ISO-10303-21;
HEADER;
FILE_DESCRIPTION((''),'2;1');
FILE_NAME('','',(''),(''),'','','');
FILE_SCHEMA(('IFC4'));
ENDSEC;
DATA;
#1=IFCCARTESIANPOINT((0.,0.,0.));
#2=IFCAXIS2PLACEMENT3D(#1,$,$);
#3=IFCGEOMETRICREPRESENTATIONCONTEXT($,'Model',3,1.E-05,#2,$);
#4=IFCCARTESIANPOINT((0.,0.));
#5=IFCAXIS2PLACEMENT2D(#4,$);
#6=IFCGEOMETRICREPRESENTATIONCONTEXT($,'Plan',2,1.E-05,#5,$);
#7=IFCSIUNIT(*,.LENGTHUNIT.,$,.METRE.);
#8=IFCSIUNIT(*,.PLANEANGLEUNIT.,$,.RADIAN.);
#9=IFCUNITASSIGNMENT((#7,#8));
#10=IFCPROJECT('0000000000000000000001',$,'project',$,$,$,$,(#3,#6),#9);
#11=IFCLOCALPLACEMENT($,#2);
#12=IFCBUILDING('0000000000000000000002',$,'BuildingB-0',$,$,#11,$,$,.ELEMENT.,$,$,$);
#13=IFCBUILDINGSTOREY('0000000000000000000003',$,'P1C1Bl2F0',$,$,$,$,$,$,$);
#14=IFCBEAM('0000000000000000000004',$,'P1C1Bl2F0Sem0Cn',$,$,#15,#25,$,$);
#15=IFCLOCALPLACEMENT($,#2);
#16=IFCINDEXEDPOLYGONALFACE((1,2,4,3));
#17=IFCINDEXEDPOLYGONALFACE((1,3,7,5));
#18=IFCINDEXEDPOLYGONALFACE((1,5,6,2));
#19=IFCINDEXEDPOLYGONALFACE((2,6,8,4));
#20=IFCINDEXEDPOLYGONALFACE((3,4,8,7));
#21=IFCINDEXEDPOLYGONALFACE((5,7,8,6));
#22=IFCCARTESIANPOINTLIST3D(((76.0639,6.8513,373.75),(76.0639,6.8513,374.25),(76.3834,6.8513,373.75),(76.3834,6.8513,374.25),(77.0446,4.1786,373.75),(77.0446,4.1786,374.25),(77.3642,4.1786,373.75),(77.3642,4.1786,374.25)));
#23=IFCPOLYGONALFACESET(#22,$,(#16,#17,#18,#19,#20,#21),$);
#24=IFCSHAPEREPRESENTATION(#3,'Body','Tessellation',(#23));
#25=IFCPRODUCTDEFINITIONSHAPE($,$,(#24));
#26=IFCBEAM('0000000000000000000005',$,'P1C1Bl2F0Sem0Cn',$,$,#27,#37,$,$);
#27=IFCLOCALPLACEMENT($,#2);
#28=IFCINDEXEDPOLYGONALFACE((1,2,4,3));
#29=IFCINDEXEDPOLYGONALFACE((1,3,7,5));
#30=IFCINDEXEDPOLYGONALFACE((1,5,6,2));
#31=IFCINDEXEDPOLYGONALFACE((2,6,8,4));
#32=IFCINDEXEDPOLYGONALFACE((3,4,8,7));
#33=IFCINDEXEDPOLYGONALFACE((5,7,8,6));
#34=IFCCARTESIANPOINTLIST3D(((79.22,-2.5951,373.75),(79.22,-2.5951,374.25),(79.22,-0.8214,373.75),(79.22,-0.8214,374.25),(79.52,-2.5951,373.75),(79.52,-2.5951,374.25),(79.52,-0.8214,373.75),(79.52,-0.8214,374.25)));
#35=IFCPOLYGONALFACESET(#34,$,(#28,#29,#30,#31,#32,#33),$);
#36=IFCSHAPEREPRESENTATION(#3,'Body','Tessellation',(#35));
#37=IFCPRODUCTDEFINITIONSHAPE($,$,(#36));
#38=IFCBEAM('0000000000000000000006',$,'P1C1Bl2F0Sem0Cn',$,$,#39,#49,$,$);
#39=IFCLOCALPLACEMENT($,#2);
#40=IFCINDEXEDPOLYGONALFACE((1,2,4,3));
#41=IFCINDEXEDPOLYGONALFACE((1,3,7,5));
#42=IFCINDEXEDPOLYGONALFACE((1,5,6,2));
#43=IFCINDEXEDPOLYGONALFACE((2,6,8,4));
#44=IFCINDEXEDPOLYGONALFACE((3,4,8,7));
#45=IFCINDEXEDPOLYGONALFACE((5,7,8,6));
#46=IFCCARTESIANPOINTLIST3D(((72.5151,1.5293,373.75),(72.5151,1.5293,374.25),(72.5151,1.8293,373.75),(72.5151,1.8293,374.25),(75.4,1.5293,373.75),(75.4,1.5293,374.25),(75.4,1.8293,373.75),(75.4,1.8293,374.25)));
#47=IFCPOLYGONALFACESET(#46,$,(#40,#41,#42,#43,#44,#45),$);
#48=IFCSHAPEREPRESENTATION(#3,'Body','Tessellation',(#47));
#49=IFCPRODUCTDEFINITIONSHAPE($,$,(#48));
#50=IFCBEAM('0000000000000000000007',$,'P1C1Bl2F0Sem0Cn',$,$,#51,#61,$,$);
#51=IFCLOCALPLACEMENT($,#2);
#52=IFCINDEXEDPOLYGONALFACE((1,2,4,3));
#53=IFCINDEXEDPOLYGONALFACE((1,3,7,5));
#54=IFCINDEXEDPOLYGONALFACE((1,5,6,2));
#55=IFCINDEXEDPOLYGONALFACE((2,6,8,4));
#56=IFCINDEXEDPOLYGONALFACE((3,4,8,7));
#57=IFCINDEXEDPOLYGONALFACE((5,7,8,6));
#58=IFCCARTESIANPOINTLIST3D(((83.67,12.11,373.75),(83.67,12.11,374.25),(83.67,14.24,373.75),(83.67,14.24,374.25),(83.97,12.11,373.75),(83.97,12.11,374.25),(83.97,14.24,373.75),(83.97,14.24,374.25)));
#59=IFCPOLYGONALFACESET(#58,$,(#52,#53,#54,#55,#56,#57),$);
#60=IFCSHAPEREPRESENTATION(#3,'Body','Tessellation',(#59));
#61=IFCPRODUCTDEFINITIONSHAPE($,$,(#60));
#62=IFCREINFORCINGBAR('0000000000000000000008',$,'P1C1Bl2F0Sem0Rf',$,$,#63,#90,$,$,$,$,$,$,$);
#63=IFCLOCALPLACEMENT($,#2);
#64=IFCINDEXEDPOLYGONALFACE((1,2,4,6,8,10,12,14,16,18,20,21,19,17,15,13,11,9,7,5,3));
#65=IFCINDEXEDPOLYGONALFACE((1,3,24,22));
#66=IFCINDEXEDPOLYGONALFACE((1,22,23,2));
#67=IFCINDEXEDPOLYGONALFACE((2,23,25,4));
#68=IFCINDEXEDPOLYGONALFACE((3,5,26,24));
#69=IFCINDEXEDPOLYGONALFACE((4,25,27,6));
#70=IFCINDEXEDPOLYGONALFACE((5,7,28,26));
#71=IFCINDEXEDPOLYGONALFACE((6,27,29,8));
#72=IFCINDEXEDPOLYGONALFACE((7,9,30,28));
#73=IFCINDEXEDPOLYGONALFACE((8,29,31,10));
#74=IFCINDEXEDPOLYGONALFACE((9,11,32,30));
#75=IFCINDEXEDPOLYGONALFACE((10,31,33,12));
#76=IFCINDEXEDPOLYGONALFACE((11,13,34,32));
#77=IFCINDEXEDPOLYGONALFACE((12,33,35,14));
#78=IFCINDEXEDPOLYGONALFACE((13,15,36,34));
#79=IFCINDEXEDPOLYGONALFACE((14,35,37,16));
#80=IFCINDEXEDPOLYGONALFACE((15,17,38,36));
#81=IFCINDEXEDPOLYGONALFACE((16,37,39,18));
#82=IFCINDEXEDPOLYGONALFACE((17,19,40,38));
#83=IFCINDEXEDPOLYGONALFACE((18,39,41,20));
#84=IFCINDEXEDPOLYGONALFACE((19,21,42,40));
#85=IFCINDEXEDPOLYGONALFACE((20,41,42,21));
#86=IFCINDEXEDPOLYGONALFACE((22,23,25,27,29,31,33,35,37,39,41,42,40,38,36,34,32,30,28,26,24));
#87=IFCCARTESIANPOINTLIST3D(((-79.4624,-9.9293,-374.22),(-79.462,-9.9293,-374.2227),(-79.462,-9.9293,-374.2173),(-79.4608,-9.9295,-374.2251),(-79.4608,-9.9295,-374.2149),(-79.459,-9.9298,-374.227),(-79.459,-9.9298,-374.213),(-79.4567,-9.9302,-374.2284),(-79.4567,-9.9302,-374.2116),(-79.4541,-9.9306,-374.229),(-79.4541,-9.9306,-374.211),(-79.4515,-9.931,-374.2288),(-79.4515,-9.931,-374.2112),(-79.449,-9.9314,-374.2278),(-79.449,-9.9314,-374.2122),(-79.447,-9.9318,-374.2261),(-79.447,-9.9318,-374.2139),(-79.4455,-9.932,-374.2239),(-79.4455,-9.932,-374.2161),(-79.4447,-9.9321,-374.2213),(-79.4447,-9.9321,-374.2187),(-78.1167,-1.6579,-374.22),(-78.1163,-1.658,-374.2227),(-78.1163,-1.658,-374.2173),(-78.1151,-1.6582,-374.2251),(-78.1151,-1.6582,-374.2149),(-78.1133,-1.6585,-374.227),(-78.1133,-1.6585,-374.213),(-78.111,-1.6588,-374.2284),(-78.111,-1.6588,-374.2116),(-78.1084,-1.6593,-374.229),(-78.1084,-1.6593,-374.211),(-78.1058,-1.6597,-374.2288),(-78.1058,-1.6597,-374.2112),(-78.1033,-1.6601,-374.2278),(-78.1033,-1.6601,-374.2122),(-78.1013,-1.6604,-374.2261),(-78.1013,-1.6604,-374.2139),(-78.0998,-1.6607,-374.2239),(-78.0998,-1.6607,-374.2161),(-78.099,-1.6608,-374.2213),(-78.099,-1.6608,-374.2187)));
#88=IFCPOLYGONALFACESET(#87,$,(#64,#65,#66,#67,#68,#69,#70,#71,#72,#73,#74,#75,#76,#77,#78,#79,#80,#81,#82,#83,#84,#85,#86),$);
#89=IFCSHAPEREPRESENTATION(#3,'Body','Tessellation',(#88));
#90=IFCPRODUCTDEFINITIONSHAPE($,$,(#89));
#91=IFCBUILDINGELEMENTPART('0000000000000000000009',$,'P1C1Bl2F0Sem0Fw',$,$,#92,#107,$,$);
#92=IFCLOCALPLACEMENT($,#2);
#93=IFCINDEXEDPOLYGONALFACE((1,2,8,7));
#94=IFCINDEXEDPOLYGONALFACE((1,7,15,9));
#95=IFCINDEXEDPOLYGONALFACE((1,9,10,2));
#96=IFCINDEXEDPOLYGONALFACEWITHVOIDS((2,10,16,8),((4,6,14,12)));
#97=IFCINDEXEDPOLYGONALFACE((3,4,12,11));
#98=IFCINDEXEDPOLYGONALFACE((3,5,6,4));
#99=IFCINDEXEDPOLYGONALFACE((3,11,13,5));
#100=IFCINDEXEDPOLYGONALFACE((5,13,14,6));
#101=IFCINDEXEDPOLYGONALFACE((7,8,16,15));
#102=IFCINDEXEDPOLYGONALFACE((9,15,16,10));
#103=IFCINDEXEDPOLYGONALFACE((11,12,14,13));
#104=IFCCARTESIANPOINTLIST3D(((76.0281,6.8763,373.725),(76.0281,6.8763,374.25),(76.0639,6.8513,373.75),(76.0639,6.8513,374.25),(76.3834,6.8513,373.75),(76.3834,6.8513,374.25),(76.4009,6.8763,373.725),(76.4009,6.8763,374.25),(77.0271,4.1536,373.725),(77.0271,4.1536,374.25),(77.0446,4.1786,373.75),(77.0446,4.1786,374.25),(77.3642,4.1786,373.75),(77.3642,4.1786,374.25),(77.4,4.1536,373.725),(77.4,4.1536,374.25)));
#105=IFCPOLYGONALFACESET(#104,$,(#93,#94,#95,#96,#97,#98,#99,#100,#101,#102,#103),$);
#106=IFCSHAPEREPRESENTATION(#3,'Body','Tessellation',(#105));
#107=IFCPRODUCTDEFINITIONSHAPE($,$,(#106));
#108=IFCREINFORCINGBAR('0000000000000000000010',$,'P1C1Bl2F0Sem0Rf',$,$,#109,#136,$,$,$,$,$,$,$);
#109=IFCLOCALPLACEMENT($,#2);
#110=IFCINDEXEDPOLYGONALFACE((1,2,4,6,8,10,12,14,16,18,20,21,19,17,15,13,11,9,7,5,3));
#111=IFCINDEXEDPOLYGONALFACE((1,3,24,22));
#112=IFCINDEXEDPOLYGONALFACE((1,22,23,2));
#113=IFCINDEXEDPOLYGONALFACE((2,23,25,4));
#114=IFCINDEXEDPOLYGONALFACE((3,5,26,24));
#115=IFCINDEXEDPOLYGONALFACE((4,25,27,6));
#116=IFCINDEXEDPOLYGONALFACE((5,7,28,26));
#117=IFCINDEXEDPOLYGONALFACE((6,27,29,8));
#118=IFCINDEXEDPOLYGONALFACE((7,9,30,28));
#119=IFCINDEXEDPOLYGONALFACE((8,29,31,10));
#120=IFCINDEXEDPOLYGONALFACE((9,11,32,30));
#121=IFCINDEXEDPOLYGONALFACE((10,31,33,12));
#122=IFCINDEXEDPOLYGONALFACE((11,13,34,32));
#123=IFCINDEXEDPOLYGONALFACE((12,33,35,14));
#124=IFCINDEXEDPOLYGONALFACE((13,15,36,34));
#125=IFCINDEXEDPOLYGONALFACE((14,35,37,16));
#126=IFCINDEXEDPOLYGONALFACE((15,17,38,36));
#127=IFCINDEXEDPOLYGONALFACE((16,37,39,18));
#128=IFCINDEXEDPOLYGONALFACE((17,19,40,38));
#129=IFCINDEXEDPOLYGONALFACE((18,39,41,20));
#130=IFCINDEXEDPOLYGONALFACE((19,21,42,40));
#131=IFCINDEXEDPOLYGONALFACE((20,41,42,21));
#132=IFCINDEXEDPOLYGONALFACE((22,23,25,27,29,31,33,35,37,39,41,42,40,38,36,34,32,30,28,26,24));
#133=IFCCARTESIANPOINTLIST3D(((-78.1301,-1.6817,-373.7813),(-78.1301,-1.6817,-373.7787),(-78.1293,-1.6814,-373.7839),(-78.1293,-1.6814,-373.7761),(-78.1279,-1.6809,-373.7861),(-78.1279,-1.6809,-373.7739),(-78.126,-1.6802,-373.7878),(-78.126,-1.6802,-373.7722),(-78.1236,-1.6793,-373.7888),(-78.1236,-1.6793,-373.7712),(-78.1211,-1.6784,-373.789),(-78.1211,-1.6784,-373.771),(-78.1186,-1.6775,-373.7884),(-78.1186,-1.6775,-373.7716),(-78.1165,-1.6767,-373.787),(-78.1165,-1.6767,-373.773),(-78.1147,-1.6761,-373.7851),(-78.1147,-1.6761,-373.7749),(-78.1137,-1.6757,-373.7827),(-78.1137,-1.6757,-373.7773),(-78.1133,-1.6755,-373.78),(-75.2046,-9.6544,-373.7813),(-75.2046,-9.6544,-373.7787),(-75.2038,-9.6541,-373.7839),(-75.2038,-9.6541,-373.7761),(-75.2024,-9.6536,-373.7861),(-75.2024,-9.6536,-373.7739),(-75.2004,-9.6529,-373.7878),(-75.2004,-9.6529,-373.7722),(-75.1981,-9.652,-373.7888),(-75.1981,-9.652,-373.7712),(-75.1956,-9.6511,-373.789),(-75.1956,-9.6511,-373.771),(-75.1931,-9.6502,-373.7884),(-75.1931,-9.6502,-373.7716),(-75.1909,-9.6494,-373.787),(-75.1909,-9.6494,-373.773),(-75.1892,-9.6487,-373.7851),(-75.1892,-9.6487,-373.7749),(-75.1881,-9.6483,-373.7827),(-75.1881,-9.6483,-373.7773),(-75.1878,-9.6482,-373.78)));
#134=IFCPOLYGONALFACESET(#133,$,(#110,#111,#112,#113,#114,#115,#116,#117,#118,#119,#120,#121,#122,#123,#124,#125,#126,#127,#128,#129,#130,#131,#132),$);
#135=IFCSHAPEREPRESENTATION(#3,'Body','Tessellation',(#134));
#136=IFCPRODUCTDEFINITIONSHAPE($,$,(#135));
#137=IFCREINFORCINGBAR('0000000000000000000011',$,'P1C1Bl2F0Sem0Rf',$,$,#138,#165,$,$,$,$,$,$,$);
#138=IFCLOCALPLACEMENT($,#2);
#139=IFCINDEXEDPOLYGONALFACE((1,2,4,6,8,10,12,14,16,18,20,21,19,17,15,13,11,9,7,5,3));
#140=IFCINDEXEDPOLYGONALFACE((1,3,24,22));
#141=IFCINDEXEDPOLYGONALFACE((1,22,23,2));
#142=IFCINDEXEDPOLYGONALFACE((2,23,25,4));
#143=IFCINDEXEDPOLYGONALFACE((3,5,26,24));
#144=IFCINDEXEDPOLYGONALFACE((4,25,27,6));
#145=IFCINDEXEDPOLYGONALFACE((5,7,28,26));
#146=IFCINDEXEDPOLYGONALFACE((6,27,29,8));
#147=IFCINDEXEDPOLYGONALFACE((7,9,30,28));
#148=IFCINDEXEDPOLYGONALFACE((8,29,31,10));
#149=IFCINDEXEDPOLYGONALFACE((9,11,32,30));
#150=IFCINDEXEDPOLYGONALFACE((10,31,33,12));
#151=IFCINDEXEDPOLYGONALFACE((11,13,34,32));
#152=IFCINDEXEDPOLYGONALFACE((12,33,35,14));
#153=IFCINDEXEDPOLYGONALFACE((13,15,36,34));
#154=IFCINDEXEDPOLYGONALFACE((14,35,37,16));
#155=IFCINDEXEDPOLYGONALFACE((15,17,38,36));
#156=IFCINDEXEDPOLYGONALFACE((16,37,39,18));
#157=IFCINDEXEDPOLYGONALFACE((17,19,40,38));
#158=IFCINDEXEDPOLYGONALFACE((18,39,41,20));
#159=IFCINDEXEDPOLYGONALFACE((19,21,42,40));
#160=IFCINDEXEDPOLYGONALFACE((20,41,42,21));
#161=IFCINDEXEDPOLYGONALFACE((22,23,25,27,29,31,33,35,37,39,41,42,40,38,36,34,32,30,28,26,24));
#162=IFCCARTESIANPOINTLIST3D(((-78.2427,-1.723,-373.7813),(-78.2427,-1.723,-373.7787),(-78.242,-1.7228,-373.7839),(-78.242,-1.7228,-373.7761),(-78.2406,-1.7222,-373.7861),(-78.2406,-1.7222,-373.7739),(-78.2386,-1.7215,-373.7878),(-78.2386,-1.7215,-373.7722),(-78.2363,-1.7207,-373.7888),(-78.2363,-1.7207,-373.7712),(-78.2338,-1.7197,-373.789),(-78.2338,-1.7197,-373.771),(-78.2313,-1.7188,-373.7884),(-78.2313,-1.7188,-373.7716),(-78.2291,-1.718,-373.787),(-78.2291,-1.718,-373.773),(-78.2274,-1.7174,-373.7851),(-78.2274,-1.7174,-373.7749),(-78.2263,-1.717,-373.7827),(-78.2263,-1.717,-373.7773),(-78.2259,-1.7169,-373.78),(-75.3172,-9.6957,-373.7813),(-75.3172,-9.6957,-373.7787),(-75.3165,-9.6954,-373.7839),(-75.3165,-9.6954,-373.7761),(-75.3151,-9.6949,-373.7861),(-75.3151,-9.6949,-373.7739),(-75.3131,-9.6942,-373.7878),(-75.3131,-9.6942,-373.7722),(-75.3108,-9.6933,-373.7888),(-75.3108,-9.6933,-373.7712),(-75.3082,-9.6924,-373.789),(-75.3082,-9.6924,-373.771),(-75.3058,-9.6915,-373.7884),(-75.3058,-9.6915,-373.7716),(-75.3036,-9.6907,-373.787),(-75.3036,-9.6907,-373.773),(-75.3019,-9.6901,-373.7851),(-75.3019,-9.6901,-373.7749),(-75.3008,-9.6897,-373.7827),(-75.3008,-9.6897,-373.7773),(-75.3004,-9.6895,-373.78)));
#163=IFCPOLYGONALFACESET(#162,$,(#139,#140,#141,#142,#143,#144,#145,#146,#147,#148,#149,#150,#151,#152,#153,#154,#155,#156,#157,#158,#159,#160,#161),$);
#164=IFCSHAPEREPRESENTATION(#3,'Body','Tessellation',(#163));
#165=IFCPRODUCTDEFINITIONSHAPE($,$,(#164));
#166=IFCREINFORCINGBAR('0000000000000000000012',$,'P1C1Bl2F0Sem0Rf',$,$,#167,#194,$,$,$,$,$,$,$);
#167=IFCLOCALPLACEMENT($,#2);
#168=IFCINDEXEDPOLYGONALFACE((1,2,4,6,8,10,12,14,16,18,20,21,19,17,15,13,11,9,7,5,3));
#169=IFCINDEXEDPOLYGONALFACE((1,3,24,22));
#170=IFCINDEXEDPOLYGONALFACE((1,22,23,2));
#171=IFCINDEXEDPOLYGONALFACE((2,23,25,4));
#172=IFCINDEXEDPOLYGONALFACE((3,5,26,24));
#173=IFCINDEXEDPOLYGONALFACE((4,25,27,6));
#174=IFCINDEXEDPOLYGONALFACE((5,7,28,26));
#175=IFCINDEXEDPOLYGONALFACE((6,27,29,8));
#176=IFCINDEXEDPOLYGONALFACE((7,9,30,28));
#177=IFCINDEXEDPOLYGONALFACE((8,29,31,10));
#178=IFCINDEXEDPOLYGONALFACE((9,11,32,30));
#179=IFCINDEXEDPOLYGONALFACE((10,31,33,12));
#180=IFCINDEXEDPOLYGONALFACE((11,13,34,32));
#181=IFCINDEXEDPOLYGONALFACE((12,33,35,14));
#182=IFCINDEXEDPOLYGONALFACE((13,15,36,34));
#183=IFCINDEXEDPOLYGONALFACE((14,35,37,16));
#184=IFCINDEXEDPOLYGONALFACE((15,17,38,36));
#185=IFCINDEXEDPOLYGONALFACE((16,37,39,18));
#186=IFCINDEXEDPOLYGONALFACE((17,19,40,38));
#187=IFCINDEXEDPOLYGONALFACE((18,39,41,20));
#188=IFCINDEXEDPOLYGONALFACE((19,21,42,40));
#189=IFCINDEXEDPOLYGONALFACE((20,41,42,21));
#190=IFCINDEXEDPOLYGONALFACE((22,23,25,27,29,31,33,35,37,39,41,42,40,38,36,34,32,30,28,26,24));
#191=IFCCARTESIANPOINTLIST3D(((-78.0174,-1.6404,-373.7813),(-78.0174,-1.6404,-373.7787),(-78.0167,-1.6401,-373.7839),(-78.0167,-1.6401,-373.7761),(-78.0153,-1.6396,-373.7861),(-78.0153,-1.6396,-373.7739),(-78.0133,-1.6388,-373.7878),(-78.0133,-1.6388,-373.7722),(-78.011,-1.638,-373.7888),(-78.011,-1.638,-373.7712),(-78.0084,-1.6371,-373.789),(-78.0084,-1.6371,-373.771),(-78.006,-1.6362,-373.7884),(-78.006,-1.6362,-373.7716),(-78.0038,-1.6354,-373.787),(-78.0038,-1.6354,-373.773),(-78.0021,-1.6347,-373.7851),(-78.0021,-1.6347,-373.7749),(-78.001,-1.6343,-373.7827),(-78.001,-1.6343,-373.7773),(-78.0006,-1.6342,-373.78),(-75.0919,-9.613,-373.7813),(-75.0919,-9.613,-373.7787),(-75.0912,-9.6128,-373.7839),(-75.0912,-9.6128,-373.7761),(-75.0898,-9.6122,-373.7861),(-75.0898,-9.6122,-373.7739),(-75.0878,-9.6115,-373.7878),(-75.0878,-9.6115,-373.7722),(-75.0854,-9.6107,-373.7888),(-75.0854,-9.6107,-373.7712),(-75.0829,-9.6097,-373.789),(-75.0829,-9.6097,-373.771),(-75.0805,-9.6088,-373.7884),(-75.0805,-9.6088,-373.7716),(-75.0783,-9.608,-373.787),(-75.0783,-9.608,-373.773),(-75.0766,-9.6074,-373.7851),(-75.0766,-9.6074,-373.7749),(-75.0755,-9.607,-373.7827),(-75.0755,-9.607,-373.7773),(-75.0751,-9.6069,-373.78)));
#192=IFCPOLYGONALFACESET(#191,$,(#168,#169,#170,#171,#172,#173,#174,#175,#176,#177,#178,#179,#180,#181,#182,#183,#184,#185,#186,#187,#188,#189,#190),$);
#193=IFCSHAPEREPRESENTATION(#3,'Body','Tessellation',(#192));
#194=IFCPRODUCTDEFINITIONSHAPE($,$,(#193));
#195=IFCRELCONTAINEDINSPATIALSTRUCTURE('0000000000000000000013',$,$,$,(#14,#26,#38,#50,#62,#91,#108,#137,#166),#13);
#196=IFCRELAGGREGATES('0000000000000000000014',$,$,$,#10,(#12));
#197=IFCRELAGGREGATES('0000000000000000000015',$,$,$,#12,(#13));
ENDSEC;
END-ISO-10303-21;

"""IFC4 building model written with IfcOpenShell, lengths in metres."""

from ifc_helpers import new_model, entity, si_unit, origin, origin_2d, place, context, project, spatial, polyline, outline, extrude, element, save


model = new_model("IFC4")

# Units and contexts
model_context = context("Model", 3, precision=1e-05, world=origin())
plan_context = context("Plan", 2, precision=1e-05, world=origin_2d())
ifc_project = project(units=[si_unit("LENGTHUNIT", "METRE"), si_unit("PLANEANGLEUNIT", "RADIAN")], contexts=[model_context, plan_context])

# Building, storey
building_placement = place(None, origin())
building = spatial("IfcBuilding", under=ifc_project, at=building_placement, Name="BuildingB-0", CompositionType="ELEMENT")
storey = spatial("IfcBuildingStorey", under=building, Name="P1C1Bl2F0")

# Beams
element("IfcBeam", 1, inside=storey, Name="P1C1Bl2F0Sem0Cn", context=model_context, shape_type="SweptSolid", body=[
    extrude(outline(polyline([(77.3642, 4.1786, 373.75), (77.0446, 4.1786, 373.75), (76.0639, 6.8513, 373.75), (76.3834, 6.8513, 373.75), (77.3642, 4.1786, 373.75)])), None, (0.0, 0.0, 1.0), 0.5),
])
element("IfcBeam", 2, inside=storey, Name="P1C1Bl2F0Sem0Cn", context=model_context, shape_type="SweptSolid", body=[
    extrude(outline(polyline([(79.52, -2.5951, 373.75), (79.22, -2.5951, 373.75), (79.22, -0.8214, 373.75), (79.52, -0.8214, 373.75), (79.52, -2.5951, 373.75)])), None, (0.0, 0.0, 1.0), 0.5),
])
element("IfcBeam", 3, inside=storey, Name="P1C1Bl2F0Sem0Cn", context=model_context, shape_type="SweptSolid", body=[
    extrude(outline(polyline([(75.4, 1.5293, 373.75), (75.4, 1.8293, 373.75), (72.5151, 1.8293, 373.75), (72.5151, 1.5293, 373.75), (75.4, 1.5293, 373.75)])), None, (0.0, 0.0, 1.0), 0.5),
])
element("IfcBeam", 4, inside=storey, Name="P1C1Bl2F0Sem0Cn", context=model_context, shape_type="SweptSolid", body=[
    extrude(outline(polyline([(83.97, 12.11, 373.75), (83.67, 12.11, 373.75), (83.67, 14.24, 373.75), (83.97, 14.24, 373.75), (83.97, 12.11, 373.75)])), None, (0.0, 0.0, 1.0), 0.5),
])

# Reinforcing bar
element("IfcReinforcingBar", 5, inside=storey, Name="P1C1Bl2F0Sem0Rf", context=model_context, shape_type="SweptSolid", body=[
    entity("IfcSurfaceCurveSweptAreaSolid", entity("IfcCircleProfileDef", "AREA", None, None, 0.009), None, entity("IfcPolyline", [entity("IfcCartesianPoint", [79.4535, 9.9307, 374.22]), entity("IfcCartesianPoint", [78.1078, 1.6594, 374.22])]), None, None, entity("IfcPlane", entity("IfcAxis2Placement3D", entity("IfcCartesianPoint", [79.4535, 9.9307, 374.22]), entity("IfcDirection", [0.0, 0.0, 1.0]), entity("IfcDirection", [1.0, 0.0, 0.0])))),
])

# Building element part, opening
building_element_part_1 = element("IfcBuildingElementPart", 6, inside=storey, Name="P1C1Bl2F0Sem0Fw", context=model_context, shape_type="SweptSolid", body=[
    extrude(outline(polyline([(77.4, 4.1536, 373.725), (77.0271, 4.1536, 373.725), (76.0281, 6.8763, 373.725), (76.4009, 6.8763, 373.725), (77.4, 4.1536, 373.725)])), None, (0.0, 0.0, 1.0), 0.525),
])
element("IfcOpeningElement", 7, inside=storey, cuts=building_element_part_1, context=model_context, shape_type="SweptSolid", body=[
    extrude(outline(polyline([(77.3642, 4.1786, 373.75), (77.0446, 4.1786, 373.75), (76.0639, 6.8513, 373.75), (76.3834, 6.8513, 373.75), (77.3642, 4.1786, 373.75)])), None, (0.0, 0.0, 1.0), 0.5),
])

# Reinforcing bars
element("IfcReinforcingBar", 8, inside=storey, Name="P1C1Bl2F0Sem0Rf", context=model_context, shape_type="SweptSolid", body=[
    entity("IfcSurfaceCurveSweptAreaSolid", entity("IfcCircleProfileDef", "AREA", None, None, 0.009), None, entity("IfcPolyline", [entity("IfcCartesianPoint", [78.1217, 1.6786, 373.78]), entity("IfcCartesianPoint", [75.1962, 9.6513, 373.78])]), None, None, entity("IfcPlane", entity("IfcAxis2Placement3D", entity("IfcCartesianPoint", [78.1217, 1.6786, 373.78]), entity("IfcDirection", [0.0, 0.0, 1.0]), entity("IfcDirection", [1.0, 0.0, 0.0])))),
])
element("IfcReinforcingBar", 9, inside=storey, Name="P1C1Bl2F0Sem0Rf", context=model_context, shape_type="SweptSolid", body=[
    entity("IfcSurfaceCurveSweptAreaSolid", entity("IfcCircleProfileDef", "AREA", None, None, 0.009), None, entity("IfcPolyline", [entity("IfcCartesianPoint", [78.2344, 1.72, 373.78]), entity("IfcCartesianPoint", [75.3089, 9.6926, 373.78])]), None, None, entity("IfcPlane", entity("IfcAxis2Placement3D", entity("IfcCartesianPoint", [78.2344, 1.72, 373.78]), entity("IfcDirection", [0.0, 0.0, 1.0]), entity("IfcDirection", [1.0, 0.0, 0.0])))),
])
element("IfcReinforcingBar", 10, inside=storey, Name="P1C1Bl2F0Sem0Rf", context=model_context, shape_type="SweptSolid", body=[
    entity("IfcSurfaceCurveSweptAreaSolid", entity("IfcCircleProfileDef", "AREA", None, None, 0.009), None, entity("IfcPolyline", [entity("IfcCartesianPoint", [78.0091, 1.6373, 373.78]), entity("IfcCartesianPoint", [75.0836, 9.61, 373.78])]), None, None, entity("IfcPlane", entity("IfcAxis2Placement3D", entity("IfcCartesianPoint", [78.0091, 1.6373, 373.78]), entity("IfcDirection", [0.0, 0.0, 1.0]), entity("IfcDirection", [1.0, 0.0, 0.0])))),
])

save(model, "model.ifc")
